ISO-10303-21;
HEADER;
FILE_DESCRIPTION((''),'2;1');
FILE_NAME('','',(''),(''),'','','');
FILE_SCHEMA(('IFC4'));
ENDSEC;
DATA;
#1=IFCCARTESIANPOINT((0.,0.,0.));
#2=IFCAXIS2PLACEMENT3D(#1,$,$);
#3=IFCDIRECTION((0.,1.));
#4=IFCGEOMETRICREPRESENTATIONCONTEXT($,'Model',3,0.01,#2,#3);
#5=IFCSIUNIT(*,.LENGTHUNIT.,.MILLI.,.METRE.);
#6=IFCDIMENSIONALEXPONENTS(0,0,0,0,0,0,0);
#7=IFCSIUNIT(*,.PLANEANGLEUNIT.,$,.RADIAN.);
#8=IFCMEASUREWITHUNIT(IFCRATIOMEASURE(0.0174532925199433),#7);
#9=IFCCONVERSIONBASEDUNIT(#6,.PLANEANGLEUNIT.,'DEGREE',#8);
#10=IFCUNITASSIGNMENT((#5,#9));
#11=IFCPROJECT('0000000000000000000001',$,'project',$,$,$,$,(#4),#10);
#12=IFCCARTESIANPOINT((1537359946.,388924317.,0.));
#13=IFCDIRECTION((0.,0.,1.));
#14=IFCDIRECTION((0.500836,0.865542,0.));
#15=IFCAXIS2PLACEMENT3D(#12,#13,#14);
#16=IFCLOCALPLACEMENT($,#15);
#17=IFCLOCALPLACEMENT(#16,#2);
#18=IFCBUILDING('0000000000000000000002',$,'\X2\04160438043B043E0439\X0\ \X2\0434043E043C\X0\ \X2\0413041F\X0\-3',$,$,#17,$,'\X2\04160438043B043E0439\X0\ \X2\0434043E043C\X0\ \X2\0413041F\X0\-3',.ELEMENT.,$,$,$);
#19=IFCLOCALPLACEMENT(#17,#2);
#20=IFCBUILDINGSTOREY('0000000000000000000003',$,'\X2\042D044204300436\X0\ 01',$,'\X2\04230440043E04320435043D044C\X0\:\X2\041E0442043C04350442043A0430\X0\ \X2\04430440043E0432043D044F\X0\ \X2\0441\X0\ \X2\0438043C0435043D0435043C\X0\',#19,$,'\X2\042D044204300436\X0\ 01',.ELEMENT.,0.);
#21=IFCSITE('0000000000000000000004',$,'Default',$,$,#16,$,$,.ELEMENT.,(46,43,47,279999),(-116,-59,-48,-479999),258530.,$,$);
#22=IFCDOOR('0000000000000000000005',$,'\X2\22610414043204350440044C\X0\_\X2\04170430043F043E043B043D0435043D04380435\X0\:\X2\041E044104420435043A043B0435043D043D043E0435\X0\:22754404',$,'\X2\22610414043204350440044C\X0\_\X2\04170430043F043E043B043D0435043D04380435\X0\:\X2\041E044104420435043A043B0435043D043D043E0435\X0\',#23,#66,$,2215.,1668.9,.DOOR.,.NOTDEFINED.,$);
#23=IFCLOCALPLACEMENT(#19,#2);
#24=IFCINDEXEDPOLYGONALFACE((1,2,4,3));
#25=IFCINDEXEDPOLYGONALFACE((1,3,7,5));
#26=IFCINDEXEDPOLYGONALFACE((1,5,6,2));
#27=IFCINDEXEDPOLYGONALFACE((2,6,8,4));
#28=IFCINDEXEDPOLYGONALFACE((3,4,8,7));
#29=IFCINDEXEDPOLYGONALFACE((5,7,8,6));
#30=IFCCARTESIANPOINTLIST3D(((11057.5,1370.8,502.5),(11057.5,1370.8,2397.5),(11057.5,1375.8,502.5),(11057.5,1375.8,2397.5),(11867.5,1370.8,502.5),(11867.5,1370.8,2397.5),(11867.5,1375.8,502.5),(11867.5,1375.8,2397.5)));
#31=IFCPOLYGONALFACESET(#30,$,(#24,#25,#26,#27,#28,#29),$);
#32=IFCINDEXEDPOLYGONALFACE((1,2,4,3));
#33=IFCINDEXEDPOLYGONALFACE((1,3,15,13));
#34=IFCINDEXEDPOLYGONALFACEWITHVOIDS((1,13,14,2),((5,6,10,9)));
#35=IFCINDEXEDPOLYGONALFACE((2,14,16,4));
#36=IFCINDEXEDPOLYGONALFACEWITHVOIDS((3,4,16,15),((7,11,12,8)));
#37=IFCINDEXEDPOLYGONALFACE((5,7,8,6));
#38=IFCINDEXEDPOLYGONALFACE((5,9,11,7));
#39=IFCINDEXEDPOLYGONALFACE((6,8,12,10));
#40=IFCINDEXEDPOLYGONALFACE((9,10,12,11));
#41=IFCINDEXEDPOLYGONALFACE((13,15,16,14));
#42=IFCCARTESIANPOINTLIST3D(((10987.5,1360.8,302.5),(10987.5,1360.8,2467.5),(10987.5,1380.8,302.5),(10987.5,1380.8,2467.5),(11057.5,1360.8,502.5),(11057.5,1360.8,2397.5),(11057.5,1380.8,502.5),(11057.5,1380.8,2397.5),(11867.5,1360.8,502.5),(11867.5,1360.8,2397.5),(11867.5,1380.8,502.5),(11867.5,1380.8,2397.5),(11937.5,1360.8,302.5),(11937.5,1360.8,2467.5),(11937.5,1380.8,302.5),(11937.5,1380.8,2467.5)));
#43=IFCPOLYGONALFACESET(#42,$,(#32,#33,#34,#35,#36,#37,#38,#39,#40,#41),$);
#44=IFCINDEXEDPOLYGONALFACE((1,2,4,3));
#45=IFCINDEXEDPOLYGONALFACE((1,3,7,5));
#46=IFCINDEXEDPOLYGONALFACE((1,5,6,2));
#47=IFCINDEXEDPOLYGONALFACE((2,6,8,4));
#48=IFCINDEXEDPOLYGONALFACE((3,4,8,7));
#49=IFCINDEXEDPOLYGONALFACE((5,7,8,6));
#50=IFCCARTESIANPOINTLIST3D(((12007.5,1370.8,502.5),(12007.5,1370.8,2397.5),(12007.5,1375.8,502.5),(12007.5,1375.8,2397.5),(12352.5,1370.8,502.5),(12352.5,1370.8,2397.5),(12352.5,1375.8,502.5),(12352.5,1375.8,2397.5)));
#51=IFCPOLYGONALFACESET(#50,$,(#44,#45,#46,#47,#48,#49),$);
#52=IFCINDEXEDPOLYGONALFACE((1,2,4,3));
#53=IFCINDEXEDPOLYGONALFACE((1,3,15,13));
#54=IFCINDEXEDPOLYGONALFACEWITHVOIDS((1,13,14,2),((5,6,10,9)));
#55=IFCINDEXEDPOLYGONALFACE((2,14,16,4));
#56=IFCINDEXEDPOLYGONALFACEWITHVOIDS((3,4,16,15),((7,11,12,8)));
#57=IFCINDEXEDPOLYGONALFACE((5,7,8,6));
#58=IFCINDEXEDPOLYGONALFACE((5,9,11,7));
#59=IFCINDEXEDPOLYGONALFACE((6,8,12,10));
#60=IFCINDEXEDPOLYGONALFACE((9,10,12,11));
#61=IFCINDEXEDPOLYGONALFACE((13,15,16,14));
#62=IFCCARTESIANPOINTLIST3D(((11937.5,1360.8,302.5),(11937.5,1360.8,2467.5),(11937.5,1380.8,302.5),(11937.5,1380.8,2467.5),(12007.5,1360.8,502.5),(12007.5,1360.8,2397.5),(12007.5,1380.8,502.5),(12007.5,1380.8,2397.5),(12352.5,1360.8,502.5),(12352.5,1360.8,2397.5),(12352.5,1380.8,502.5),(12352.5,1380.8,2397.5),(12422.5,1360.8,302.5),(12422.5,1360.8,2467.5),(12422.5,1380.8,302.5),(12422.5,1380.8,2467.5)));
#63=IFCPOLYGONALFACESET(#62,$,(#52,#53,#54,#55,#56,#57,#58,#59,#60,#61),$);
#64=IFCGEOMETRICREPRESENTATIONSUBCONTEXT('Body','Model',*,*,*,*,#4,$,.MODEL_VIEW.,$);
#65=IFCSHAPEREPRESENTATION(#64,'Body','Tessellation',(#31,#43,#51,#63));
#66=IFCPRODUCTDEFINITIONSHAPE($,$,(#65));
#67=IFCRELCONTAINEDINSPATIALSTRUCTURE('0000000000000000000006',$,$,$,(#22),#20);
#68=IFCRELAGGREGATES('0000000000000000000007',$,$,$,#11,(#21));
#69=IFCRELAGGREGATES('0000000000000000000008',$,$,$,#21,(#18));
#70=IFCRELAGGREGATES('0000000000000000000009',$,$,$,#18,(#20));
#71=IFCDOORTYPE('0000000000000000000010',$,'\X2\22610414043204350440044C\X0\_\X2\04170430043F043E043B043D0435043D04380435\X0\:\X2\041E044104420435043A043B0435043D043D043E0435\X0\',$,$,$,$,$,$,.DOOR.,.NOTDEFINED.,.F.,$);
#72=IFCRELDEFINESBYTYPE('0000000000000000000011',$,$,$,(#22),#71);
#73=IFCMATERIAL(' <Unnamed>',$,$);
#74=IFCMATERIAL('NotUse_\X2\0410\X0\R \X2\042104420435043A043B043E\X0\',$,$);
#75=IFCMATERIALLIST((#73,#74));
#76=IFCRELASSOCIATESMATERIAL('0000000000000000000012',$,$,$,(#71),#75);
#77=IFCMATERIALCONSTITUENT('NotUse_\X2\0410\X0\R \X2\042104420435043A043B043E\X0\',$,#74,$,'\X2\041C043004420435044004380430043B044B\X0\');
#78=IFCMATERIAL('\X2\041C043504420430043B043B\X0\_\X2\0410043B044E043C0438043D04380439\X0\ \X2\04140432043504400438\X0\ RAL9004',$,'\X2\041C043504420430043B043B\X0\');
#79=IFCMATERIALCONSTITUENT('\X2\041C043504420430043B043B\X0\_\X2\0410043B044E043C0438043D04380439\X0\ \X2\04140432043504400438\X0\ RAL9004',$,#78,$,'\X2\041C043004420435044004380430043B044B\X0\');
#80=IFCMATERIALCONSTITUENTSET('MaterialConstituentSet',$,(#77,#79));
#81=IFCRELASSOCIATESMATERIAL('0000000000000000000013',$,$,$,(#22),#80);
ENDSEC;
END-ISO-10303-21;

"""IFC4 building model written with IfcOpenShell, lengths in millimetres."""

from ifc_helpers import new_model, entity, si_unit, converted_unit, direction, frame, frame_2d, origin, place, context, subcontext, project, spatial, polyline, rectangle, outline, extrude, source, transform, mapped, material, material_list, constituent, constituent_set, type_object, type_shapes, element, save


model = new_model("IFC4")

# Units and contexts
model_context = context("Model", 3, precision=0.01, world=origin(), true_north=direction((0.0, 1.0)))
body_context = subcontext(model_context, "Body", "Model", "MODEL_VIEW")
ifc_project = project(units=[si_unit("LENGTHUNIT", "METRE", prefix="MILLI"), converted_unit("PLANEANGLEUNIT", "DEGREE", entity("IfcRatioMeasure", 0.0174532925199433), si_unit("PLANEANGLEUNIT", "RADIAN"), dimensions=[0, 0, 0, 0, 0, 0, 0])], contexts=[model_context])

# Site, building, storey
site_placement = place(None, frame((1537359946.0, 388924317.0, 0.0), z_axis=(0.0, 0.0, 1.0), x_axis=(0.500836, 0.865542, 0.0)))
site = spatial("IfcSite", under=ifc_project, at=site_placement, Name="Default", CompositionType="ELEMENT", RefLatitude=(46, 43, 47, 279999), RefLongitude=(-116, -59, -48, -479999), RefElevation=258530.0)
building_placement = place(site_placement, origin())
building = spatial("IfcBuilding", under=site, at=building_placement, Name="Жилой дом ГП-3", LongName="Жилой дом ГП-3", CompositionType="ELEMENT")
storey_placement = place(building_placement, origin())
storey = spatial("IfcBuildingStorey", under=building, at=storey_placement, Name="Этаж 01", ObjectType="Уровень:Отметка уровня с именем", LongName="Этаж 01", CompositionType="ELEMENT", Elevation=0.0)

# Shared definitions
ifc_material_1 = material(Name="NotUse_АR Стекло")

# Door
ifc_constituent_1 = constituent(ifc_material_1, Name="NotUse_АR Стекло", Category="Материалы")
ifc_material_2 = material(Name="Металл_Алюминий Двери RAL9004", Category="Металл")
ifc_constituent_2 = constituent(ifc_material_2, Name="Металл_Алюминий Двери RAL9004", Category="Материалы")
ifc_constituent_set = constituent_set(constituents=[ifc_constituent_1, ifc_constituent_2], Name="MaterialConstituentSet")
ifc_material_3 = material(Name=" <Unnamed>")
ifc_material_list = material_list([ifc_material_3, ifc_material_1])
door_type = type_object("IfcDoorType", Name="≡Дверь_Заполнение:Остекленное", OperationType="NOTDEFINED", ParameterTakesPrecedence=False, PredefinedType="DOOR", material=ifc_material_list)
shared_shape_1 = source(origin(), body_context, "Body", "SweptSolid", [
    extrude(rectangle(XDim=810.0, YDim=5.0, at=frame_2d((0.0, 0.0), x_axis=(1.0, 0.0))), frame((-242.5, 12.5, 200.0), z_axis=(0.0, 0.0, 1.0), x_axis=(-1.0, 0.0, 0.0)), (0.0, 0.0, 1.0), 1895.0),
    extrude(outline(polyline([(-1082.5, -475.0), (1082.5, -475.0), (1082.5, 475.0), (-1082.5, 475.0), (-1082.5, -475.0)]), holes=[polyline([(-1012.5, -405.0), (-1012.5, 405.0), (882.5, 405.0), (882.5, -405.0), (-1012.5, -405.0)])]), frame((-242.5, 0.0, 1082.5), z_axis=(0.0, 1.0, 0.0), x_axis=(0.0, 0.0, -1.0)), (0.0, 0.0, 1.0), 20.0),
    extrude(rectangle(XDim=345.0, YDim=5.0, at=frame_2d((0.0, 0.0), x_axis=(1.0, 0.0))), frame((475.0, 12.5, 200.0), z_axis=(0.0, 0.0, 1.0), x_axis=(-1.0, 0.0, 0.0)), (0.0, 0.0, 1.0), 1895.0),
    extrude(outline(polyline([(-1082.5, -242.5), (1082.5, -242.5), (1082.5, 242.5), (-1082.5, 242.5), (-1082.5, -242.5)]), holes=[polyline([(-1012.5, -172.5), (-1012.5, 172.5), (882.5, 172.5), (882.5, -172.5), (-1012.5, -172.5)])]), frame((475.0, 0.0, 1082.5), z_axis=(0.0, 1.0, 0.0), x_axis=(0.0, 0.0, -1.0)), (0.0, 0.0, 1.0), 20.0),
])
type_shapes(door_type, [shared_shape_1])
door_placement = place(storey_placement, frame((11705.0, 1360.8, 302.5)))
element("IfcDoor", 1, at=door_placement, inside=storey, type_object=door_type, material=ifc_constituent_set, Name="≡Дверь_Заполнение:Остекленное:22754404", ObjectType="≡Дверь_Заполнение:Остекленное", OperationType="NOTDEFINED", OverallHeight=2215.0, OverallWidth=1668.9, PredefinedType="DOOR", context=body_context, shape_type="MappedRepresentation", body=[
    mapped(shared_shape_1, transform((0.0, 0.0, 0.0), scale=1.0)),
])

save(model, "model.ifc")
